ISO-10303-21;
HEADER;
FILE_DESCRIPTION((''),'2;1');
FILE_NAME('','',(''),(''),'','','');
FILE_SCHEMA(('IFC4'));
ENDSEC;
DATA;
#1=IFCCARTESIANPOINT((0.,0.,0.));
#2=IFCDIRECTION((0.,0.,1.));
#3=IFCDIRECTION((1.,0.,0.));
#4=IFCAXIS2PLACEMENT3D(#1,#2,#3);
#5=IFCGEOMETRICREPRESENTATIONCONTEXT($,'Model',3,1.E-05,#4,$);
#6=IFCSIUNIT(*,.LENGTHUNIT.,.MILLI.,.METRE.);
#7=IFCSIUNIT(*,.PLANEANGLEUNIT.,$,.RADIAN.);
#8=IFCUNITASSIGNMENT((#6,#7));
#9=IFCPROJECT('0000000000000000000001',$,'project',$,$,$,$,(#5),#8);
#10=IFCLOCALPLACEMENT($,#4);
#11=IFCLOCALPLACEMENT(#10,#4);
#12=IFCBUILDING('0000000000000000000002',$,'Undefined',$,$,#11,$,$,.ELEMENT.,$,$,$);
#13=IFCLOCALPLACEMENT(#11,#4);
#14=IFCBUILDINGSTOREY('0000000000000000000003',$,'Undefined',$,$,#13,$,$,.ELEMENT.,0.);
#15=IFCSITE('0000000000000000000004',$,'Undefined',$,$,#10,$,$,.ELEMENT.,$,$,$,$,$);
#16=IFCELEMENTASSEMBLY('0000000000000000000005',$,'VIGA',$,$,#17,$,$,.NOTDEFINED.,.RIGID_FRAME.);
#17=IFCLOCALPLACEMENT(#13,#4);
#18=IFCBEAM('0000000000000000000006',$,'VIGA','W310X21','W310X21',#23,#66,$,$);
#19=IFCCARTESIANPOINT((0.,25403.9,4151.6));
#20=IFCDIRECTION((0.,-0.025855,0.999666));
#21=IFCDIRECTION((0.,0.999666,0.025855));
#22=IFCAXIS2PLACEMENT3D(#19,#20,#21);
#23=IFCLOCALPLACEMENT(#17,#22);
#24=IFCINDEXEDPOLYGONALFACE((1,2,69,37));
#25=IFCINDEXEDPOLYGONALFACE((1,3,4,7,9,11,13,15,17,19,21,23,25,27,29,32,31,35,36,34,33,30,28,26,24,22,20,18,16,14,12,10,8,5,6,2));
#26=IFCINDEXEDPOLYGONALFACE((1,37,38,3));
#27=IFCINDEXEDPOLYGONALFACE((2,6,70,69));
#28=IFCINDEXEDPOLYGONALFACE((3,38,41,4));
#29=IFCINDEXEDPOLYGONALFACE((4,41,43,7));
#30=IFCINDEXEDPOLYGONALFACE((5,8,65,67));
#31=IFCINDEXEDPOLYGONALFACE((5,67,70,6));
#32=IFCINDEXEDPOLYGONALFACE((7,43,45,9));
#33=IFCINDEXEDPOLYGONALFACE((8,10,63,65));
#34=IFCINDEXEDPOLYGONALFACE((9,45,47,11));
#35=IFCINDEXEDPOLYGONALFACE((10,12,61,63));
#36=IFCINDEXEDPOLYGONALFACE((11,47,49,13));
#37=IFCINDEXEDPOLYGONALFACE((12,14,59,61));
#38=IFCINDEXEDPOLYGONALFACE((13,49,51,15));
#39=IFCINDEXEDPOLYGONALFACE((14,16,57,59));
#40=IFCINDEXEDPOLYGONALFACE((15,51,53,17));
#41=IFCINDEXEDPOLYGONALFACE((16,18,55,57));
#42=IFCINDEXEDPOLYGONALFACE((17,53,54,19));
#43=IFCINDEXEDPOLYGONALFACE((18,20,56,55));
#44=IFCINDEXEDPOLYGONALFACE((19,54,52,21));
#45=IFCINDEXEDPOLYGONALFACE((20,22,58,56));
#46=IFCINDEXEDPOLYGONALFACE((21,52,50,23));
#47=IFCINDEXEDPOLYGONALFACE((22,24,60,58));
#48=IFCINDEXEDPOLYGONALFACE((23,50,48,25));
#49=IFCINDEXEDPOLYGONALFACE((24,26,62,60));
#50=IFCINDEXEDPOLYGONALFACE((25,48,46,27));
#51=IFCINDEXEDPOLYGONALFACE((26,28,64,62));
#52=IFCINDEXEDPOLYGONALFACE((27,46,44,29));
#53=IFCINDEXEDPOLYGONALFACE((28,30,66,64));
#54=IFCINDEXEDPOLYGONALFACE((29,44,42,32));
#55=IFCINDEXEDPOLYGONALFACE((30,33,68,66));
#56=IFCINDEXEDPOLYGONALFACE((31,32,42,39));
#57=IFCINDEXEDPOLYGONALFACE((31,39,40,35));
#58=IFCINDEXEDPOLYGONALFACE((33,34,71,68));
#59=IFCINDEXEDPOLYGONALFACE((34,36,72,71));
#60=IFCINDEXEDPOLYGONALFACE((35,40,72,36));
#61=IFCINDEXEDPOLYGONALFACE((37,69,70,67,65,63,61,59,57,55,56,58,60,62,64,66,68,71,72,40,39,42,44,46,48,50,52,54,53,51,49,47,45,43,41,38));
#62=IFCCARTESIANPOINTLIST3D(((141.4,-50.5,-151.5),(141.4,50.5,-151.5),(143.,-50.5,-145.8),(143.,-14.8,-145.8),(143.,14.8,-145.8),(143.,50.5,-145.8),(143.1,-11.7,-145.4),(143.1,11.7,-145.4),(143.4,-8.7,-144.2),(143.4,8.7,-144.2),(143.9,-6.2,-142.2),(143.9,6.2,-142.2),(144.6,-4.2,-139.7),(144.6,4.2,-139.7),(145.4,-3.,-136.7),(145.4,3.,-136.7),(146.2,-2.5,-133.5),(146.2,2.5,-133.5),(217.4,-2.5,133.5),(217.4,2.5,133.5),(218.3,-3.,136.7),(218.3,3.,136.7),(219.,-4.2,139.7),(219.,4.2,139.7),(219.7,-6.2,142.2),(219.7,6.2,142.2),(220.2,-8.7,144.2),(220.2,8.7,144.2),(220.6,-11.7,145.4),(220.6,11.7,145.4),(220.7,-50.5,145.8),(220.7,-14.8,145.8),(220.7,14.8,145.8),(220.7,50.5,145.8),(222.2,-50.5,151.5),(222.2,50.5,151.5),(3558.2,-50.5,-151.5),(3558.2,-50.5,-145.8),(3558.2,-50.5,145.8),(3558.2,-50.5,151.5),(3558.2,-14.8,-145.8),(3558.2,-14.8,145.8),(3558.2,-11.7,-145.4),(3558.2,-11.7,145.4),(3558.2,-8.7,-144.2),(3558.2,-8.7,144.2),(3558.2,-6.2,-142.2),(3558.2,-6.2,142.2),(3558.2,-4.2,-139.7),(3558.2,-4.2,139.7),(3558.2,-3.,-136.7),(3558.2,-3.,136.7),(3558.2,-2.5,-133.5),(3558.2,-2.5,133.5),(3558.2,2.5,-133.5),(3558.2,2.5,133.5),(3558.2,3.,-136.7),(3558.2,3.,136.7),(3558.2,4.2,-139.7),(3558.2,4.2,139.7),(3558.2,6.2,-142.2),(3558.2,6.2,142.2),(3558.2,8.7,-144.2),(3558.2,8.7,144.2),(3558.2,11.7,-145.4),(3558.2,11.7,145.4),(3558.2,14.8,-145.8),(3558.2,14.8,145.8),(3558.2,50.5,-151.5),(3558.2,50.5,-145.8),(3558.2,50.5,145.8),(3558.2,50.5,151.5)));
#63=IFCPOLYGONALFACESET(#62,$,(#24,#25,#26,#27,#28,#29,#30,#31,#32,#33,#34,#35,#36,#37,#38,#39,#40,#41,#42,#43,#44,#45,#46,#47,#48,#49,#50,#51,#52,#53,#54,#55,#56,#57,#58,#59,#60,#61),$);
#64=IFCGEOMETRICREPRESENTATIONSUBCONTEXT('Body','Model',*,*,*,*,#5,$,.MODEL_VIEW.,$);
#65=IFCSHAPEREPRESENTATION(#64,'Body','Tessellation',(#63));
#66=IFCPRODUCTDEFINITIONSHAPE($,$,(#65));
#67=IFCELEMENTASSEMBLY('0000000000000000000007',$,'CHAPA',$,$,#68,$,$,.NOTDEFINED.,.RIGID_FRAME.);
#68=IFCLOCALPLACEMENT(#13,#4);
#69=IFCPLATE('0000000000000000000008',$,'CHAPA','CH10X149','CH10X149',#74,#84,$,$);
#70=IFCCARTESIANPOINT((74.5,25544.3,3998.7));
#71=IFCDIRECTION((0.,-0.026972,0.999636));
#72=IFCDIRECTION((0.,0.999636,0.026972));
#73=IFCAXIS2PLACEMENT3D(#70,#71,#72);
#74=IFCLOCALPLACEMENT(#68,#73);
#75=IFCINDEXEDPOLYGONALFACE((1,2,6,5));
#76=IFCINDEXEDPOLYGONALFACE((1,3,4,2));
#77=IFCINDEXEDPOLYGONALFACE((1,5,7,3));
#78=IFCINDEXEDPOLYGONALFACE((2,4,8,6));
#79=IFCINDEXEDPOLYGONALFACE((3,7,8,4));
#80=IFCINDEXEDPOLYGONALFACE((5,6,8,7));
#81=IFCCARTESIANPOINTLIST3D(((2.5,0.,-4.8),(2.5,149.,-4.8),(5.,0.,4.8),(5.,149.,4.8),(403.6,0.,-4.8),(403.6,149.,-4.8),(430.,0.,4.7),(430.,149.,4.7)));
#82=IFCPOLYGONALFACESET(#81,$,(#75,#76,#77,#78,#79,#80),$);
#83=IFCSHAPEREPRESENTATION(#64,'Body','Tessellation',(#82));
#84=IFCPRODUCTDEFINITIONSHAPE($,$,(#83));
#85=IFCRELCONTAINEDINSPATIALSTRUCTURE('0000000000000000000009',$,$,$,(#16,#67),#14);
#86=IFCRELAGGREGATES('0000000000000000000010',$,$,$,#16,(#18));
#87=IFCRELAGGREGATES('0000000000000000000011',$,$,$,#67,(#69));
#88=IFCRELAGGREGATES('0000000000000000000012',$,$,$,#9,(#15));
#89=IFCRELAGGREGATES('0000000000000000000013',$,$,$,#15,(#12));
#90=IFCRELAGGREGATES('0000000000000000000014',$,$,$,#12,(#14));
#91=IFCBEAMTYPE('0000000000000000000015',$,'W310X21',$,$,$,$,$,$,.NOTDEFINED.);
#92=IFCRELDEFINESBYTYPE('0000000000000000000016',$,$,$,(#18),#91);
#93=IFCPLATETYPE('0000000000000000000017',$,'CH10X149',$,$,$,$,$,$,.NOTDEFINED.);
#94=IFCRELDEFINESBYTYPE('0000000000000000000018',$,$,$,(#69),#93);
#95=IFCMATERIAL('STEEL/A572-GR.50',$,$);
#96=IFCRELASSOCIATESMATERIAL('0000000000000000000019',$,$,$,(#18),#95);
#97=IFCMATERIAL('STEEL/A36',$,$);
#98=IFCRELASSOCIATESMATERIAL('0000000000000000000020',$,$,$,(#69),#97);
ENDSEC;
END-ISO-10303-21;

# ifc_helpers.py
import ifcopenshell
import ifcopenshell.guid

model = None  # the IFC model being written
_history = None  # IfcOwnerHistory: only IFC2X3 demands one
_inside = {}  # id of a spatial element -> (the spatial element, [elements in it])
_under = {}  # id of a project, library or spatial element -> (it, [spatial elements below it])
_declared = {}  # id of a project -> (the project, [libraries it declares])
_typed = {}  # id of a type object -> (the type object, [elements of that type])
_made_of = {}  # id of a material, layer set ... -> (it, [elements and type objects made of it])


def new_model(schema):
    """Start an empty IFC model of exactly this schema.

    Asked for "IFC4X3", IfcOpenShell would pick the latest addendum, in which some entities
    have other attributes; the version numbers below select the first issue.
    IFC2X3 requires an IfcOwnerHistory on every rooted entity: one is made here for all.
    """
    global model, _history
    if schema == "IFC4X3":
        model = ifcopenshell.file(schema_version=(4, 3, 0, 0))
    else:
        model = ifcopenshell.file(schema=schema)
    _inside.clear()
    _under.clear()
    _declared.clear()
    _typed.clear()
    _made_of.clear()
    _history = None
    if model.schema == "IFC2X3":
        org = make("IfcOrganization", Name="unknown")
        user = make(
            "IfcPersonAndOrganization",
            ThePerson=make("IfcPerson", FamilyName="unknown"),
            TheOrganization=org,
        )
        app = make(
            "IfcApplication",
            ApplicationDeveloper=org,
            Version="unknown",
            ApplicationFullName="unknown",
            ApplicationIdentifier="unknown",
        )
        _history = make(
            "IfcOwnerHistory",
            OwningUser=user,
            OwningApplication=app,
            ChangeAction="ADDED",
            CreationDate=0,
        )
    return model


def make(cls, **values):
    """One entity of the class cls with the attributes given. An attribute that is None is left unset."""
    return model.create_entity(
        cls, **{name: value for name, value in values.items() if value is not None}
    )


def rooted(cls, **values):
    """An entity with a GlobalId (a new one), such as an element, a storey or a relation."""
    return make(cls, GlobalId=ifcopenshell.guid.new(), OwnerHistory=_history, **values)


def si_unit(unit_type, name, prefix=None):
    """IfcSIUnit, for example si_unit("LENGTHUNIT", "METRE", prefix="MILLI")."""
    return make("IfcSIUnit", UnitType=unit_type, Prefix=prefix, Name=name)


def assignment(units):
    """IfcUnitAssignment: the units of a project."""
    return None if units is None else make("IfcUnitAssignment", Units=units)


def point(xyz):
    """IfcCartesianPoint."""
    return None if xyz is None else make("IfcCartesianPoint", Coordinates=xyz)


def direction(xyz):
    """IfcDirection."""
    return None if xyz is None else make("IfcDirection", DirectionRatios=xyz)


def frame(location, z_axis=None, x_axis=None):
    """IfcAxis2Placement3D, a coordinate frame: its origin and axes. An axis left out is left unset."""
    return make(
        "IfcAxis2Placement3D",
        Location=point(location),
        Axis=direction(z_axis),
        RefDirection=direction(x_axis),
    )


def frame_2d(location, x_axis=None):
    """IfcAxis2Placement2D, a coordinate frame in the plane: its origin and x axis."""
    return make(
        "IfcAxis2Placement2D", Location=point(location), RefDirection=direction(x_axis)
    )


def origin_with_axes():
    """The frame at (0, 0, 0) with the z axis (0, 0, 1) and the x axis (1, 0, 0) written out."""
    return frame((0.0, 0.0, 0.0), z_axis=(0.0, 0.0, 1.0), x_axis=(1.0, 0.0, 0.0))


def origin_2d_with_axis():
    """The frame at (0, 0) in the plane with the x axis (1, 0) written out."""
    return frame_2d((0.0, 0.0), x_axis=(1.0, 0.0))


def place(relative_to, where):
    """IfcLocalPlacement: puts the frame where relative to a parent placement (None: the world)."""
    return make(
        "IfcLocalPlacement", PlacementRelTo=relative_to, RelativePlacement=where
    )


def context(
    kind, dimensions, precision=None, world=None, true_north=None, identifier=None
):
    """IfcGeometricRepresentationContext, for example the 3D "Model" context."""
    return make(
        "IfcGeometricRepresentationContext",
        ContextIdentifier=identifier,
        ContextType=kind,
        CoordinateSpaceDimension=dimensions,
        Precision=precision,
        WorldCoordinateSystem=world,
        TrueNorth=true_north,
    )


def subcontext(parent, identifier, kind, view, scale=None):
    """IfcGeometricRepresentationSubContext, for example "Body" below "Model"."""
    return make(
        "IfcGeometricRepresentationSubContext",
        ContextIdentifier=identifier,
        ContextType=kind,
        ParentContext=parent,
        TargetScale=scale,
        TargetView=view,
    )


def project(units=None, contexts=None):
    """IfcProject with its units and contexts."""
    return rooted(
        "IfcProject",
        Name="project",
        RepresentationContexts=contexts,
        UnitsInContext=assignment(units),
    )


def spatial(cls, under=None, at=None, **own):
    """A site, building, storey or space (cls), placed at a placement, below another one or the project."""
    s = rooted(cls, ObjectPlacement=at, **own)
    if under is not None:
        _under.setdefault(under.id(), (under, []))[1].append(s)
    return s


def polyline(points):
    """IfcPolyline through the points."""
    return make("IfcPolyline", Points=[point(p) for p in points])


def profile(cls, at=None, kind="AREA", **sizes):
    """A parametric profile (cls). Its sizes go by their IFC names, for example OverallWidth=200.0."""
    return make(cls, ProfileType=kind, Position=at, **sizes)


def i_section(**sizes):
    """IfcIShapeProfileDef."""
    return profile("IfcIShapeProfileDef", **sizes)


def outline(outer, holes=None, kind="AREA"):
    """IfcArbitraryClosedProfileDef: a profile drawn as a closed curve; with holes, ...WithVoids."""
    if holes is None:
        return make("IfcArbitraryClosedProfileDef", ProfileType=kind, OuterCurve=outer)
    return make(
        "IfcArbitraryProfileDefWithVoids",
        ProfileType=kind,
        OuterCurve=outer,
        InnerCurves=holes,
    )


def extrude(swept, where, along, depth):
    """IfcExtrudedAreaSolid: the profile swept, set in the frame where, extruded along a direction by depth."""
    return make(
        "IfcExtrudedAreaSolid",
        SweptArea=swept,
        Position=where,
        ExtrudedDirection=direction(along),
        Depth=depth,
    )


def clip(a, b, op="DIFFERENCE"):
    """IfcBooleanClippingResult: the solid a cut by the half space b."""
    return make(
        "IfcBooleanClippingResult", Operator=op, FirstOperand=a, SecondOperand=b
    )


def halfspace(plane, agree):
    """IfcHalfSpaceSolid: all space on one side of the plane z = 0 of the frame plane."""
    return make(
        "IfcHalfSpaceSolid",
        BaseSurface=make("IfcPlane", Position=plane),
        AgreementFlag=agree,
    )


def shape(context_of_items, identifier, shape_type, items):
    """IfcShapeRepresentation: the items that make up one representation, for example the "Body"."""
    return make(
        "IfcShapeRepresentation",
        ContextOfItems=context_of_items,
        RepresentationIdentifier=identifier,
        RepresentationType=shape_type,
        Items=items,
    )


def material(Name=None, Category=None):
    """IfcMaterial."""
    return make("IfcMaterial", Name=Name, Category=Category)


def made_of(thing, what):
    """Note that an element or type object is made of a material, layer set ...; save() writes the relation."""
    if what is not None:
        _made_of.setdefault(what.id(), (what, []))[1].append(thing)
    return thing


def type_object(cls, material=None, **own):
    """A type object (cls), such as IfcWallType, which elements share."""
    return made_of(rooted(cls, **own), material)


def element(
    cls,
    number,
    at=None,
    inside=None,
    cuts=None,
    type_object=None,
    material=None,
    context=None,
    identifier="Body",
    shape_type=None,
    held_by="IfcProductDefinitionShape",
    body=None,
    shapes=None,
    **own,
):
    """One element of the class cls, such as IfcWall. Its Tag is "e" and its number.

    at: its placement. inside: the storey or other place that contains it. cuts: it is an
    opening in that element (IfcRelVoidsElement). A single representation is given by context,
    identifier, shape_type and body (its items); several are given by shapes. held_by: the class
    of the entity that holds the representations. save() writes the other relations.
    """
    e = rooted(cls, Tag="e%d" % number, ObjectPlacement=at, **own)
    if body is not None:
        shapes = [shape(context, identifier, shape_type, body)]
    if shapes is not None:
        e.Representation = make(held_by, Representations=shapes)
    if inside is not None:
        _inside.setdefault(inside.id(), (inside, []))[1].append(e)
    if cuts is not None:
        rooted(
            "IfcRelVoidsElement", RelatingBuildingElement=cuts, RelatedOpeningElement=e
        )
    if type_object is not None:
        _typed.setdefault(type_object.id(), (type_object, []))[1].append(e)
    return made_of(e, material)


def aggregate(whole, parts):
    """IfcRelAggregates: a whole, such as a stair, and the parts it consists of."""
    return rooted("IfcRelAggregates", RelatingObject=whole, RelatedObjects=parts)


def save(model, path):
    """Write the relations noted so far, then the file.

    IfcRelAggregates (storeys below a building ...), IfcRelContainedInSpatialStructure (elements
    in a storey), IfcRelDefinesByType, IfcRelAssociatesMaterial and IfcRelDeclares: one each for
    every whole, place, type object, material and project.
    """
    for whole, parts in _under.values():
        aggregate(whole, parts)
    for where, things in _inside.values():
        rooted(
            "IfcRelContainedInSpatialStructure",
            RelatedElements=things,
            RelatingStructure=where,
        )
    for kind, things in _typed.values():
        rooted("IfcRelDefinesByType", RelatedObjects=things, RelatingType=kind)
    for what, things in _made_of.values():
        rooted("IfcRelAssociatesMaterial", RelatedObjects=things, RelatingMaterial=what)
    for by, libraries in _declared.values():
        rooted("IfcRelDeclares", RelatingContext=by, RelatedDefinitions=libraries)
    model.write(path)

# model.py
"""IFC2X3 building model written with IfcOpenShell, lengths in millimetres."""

from ifc_helpers import new_model, si_unit, frame, origin_with_axes, origin_2d_with_axis, place, context, subcontext, project, spatial, polyline, i_section, outline, extrude, clip, halfspace, material, type_object, element, aggregate, save


model = new_model("IFC2X3")

# Units and contexts
model_context = context("Model", 3, precision=1e-05, world=origin_with_axes())
body_context = subcontext(model_context, "Body", "Model", "MODEL_VIEW")
ifc_project = project(units=[si_unit("LENGTHUNIT", "METRE", prefix="MILLI"), si_unit("PLANEANGLEUNIT", "RADIAN")], contexts=[model_context])

# Site, building, storey
site_placement = place(None, origin_with_axes())
site = spatial("IfcSite", under=ifc_project, at=site_placement, Name="Undefined", CompositionType="ELEMENT")
building_placement = place(site_placement, origin_with_axes())
building = spatial("IfcBuilding", under=site, at=building_placement, Name="Undefined", CompositionType="ELEMENT")
storey_placement = place(building_placement, origin_with_axes())
storey = spatial("IfcBuildingStorey", under=building, at=storey_placement, Name="Undefined", CompositionType="ELEMENT", Elevation=0.0)

# Element assembly, beam
ifc_material_1 = material(Name="STEEL/A572-GR.50")
beam_type_1 = type_object("IfcBeamType", Name="W310X21", PredefinedType="NOTDEFINED")
assembly_1_placement = place(storey_placement, origin_with_axes())
assembly_1 = element("IfcElementAssembly", 1, at=assembly_1_placement, inside=storey, Name="VIGA", AssemblyPlace="NOTDEFINED", PredefinedType="RIGID_FRAME")
beam_1_placement = place(assembly_1_placement, frame((0.0, 25403.9, 4151.6), z_axis=(0.0, -0.025855, 0.999666), x_axis=(0.0, 0.999666, 0.025855)))
beam_1 = element("IfcBeam", 2, at=beam_1_placement, type_object=beam_type_1, material=ifc_material_1, Name="VIGA", Description="W310X21", ObjectType="W310X21", context=body_context, shape_type="Clipping", body=[
    clip(extrude(i_section(OverallWidth=101.0, OverallDepth=303.0, WebThickness=5.1, FlangeThickness=5.7, FilletRadius=12.3, at=origin_2d_with_axis()), frame((3558.2, 0.0, 0.0), z_axis=(-1.0, 0.0, 0.0), x_axis=(0.0, -1.0, 0.0)), (0.0, 0.0, 1.0), 3558.2), halfspace(frame((141.4, -50.5, -151.7), z_axis=(-0.966259, 0.0, 0.257573), x_axis=(0.0, 1.0, 0.0)), False)),
])
aggregate(assembly_1, [beam_1])

# Shared definitions
ifc_material_2 = material(Name="STEEL/A36")

# Element assembly, plate
plate_type_1 = type_object("IfcPlateType", Name="CH10X149", PredefinedType="NOTDEFINED")
assembly_2_placement = place(storey_placement, origin_with_axes())
assembly_2 = element("IfcElementAssembly", 3, at=assembly_2_placement, inside=storey, Name="CHAPA", AssemblyPlace="NOTDEFINED", PredefinedType="RIGID_FRAME")
plate_1_placement = place(assembly_2_placement, frame((74.5, 25544.3, 3998.7), z_axis=(0.0, -0.026972, 0.999636), x_axis=(0.0, 0.999636, 0.026972)))
plate_1 = element("IfcPlate", 4, at=plate_1_placement, type_object=plate_type_1, material=ifc_material_2, Name="CHAPA", Description="CH10X149", ObjectType="CH10X149", context=body_context, shape_type="Clipping", body=[
    clip(clip(extrude(outline(polyline([(0.0, 0.0), (430.0, 0.0), (430.0, 149.0), (0.0, 149.0), (0.0, 0.0)])), frame((0.0, 0.0, -4.8), z_axis=(0.0, 0.0, 1.0), x_axis=(1.0, 0.0, 0.0)), (0.0, 0.0, 1.0), 9.5), halfspace(frame((403.6, -500.0, -4.8), z_axis=(0.33881, 0.0, -0.940855), x_axis=(0.940855, 0.0, 0.33881)), False)), halfspace(frame((5.0, -500.0, 4.7), z_axis=(-0.965989, 0.0, 0.258583), x_axis=(-0.258583, 0.0, -0.965989)), False)),
])
aggregate(assembly_2, [plate_1])

save(model, "model.ifc")
